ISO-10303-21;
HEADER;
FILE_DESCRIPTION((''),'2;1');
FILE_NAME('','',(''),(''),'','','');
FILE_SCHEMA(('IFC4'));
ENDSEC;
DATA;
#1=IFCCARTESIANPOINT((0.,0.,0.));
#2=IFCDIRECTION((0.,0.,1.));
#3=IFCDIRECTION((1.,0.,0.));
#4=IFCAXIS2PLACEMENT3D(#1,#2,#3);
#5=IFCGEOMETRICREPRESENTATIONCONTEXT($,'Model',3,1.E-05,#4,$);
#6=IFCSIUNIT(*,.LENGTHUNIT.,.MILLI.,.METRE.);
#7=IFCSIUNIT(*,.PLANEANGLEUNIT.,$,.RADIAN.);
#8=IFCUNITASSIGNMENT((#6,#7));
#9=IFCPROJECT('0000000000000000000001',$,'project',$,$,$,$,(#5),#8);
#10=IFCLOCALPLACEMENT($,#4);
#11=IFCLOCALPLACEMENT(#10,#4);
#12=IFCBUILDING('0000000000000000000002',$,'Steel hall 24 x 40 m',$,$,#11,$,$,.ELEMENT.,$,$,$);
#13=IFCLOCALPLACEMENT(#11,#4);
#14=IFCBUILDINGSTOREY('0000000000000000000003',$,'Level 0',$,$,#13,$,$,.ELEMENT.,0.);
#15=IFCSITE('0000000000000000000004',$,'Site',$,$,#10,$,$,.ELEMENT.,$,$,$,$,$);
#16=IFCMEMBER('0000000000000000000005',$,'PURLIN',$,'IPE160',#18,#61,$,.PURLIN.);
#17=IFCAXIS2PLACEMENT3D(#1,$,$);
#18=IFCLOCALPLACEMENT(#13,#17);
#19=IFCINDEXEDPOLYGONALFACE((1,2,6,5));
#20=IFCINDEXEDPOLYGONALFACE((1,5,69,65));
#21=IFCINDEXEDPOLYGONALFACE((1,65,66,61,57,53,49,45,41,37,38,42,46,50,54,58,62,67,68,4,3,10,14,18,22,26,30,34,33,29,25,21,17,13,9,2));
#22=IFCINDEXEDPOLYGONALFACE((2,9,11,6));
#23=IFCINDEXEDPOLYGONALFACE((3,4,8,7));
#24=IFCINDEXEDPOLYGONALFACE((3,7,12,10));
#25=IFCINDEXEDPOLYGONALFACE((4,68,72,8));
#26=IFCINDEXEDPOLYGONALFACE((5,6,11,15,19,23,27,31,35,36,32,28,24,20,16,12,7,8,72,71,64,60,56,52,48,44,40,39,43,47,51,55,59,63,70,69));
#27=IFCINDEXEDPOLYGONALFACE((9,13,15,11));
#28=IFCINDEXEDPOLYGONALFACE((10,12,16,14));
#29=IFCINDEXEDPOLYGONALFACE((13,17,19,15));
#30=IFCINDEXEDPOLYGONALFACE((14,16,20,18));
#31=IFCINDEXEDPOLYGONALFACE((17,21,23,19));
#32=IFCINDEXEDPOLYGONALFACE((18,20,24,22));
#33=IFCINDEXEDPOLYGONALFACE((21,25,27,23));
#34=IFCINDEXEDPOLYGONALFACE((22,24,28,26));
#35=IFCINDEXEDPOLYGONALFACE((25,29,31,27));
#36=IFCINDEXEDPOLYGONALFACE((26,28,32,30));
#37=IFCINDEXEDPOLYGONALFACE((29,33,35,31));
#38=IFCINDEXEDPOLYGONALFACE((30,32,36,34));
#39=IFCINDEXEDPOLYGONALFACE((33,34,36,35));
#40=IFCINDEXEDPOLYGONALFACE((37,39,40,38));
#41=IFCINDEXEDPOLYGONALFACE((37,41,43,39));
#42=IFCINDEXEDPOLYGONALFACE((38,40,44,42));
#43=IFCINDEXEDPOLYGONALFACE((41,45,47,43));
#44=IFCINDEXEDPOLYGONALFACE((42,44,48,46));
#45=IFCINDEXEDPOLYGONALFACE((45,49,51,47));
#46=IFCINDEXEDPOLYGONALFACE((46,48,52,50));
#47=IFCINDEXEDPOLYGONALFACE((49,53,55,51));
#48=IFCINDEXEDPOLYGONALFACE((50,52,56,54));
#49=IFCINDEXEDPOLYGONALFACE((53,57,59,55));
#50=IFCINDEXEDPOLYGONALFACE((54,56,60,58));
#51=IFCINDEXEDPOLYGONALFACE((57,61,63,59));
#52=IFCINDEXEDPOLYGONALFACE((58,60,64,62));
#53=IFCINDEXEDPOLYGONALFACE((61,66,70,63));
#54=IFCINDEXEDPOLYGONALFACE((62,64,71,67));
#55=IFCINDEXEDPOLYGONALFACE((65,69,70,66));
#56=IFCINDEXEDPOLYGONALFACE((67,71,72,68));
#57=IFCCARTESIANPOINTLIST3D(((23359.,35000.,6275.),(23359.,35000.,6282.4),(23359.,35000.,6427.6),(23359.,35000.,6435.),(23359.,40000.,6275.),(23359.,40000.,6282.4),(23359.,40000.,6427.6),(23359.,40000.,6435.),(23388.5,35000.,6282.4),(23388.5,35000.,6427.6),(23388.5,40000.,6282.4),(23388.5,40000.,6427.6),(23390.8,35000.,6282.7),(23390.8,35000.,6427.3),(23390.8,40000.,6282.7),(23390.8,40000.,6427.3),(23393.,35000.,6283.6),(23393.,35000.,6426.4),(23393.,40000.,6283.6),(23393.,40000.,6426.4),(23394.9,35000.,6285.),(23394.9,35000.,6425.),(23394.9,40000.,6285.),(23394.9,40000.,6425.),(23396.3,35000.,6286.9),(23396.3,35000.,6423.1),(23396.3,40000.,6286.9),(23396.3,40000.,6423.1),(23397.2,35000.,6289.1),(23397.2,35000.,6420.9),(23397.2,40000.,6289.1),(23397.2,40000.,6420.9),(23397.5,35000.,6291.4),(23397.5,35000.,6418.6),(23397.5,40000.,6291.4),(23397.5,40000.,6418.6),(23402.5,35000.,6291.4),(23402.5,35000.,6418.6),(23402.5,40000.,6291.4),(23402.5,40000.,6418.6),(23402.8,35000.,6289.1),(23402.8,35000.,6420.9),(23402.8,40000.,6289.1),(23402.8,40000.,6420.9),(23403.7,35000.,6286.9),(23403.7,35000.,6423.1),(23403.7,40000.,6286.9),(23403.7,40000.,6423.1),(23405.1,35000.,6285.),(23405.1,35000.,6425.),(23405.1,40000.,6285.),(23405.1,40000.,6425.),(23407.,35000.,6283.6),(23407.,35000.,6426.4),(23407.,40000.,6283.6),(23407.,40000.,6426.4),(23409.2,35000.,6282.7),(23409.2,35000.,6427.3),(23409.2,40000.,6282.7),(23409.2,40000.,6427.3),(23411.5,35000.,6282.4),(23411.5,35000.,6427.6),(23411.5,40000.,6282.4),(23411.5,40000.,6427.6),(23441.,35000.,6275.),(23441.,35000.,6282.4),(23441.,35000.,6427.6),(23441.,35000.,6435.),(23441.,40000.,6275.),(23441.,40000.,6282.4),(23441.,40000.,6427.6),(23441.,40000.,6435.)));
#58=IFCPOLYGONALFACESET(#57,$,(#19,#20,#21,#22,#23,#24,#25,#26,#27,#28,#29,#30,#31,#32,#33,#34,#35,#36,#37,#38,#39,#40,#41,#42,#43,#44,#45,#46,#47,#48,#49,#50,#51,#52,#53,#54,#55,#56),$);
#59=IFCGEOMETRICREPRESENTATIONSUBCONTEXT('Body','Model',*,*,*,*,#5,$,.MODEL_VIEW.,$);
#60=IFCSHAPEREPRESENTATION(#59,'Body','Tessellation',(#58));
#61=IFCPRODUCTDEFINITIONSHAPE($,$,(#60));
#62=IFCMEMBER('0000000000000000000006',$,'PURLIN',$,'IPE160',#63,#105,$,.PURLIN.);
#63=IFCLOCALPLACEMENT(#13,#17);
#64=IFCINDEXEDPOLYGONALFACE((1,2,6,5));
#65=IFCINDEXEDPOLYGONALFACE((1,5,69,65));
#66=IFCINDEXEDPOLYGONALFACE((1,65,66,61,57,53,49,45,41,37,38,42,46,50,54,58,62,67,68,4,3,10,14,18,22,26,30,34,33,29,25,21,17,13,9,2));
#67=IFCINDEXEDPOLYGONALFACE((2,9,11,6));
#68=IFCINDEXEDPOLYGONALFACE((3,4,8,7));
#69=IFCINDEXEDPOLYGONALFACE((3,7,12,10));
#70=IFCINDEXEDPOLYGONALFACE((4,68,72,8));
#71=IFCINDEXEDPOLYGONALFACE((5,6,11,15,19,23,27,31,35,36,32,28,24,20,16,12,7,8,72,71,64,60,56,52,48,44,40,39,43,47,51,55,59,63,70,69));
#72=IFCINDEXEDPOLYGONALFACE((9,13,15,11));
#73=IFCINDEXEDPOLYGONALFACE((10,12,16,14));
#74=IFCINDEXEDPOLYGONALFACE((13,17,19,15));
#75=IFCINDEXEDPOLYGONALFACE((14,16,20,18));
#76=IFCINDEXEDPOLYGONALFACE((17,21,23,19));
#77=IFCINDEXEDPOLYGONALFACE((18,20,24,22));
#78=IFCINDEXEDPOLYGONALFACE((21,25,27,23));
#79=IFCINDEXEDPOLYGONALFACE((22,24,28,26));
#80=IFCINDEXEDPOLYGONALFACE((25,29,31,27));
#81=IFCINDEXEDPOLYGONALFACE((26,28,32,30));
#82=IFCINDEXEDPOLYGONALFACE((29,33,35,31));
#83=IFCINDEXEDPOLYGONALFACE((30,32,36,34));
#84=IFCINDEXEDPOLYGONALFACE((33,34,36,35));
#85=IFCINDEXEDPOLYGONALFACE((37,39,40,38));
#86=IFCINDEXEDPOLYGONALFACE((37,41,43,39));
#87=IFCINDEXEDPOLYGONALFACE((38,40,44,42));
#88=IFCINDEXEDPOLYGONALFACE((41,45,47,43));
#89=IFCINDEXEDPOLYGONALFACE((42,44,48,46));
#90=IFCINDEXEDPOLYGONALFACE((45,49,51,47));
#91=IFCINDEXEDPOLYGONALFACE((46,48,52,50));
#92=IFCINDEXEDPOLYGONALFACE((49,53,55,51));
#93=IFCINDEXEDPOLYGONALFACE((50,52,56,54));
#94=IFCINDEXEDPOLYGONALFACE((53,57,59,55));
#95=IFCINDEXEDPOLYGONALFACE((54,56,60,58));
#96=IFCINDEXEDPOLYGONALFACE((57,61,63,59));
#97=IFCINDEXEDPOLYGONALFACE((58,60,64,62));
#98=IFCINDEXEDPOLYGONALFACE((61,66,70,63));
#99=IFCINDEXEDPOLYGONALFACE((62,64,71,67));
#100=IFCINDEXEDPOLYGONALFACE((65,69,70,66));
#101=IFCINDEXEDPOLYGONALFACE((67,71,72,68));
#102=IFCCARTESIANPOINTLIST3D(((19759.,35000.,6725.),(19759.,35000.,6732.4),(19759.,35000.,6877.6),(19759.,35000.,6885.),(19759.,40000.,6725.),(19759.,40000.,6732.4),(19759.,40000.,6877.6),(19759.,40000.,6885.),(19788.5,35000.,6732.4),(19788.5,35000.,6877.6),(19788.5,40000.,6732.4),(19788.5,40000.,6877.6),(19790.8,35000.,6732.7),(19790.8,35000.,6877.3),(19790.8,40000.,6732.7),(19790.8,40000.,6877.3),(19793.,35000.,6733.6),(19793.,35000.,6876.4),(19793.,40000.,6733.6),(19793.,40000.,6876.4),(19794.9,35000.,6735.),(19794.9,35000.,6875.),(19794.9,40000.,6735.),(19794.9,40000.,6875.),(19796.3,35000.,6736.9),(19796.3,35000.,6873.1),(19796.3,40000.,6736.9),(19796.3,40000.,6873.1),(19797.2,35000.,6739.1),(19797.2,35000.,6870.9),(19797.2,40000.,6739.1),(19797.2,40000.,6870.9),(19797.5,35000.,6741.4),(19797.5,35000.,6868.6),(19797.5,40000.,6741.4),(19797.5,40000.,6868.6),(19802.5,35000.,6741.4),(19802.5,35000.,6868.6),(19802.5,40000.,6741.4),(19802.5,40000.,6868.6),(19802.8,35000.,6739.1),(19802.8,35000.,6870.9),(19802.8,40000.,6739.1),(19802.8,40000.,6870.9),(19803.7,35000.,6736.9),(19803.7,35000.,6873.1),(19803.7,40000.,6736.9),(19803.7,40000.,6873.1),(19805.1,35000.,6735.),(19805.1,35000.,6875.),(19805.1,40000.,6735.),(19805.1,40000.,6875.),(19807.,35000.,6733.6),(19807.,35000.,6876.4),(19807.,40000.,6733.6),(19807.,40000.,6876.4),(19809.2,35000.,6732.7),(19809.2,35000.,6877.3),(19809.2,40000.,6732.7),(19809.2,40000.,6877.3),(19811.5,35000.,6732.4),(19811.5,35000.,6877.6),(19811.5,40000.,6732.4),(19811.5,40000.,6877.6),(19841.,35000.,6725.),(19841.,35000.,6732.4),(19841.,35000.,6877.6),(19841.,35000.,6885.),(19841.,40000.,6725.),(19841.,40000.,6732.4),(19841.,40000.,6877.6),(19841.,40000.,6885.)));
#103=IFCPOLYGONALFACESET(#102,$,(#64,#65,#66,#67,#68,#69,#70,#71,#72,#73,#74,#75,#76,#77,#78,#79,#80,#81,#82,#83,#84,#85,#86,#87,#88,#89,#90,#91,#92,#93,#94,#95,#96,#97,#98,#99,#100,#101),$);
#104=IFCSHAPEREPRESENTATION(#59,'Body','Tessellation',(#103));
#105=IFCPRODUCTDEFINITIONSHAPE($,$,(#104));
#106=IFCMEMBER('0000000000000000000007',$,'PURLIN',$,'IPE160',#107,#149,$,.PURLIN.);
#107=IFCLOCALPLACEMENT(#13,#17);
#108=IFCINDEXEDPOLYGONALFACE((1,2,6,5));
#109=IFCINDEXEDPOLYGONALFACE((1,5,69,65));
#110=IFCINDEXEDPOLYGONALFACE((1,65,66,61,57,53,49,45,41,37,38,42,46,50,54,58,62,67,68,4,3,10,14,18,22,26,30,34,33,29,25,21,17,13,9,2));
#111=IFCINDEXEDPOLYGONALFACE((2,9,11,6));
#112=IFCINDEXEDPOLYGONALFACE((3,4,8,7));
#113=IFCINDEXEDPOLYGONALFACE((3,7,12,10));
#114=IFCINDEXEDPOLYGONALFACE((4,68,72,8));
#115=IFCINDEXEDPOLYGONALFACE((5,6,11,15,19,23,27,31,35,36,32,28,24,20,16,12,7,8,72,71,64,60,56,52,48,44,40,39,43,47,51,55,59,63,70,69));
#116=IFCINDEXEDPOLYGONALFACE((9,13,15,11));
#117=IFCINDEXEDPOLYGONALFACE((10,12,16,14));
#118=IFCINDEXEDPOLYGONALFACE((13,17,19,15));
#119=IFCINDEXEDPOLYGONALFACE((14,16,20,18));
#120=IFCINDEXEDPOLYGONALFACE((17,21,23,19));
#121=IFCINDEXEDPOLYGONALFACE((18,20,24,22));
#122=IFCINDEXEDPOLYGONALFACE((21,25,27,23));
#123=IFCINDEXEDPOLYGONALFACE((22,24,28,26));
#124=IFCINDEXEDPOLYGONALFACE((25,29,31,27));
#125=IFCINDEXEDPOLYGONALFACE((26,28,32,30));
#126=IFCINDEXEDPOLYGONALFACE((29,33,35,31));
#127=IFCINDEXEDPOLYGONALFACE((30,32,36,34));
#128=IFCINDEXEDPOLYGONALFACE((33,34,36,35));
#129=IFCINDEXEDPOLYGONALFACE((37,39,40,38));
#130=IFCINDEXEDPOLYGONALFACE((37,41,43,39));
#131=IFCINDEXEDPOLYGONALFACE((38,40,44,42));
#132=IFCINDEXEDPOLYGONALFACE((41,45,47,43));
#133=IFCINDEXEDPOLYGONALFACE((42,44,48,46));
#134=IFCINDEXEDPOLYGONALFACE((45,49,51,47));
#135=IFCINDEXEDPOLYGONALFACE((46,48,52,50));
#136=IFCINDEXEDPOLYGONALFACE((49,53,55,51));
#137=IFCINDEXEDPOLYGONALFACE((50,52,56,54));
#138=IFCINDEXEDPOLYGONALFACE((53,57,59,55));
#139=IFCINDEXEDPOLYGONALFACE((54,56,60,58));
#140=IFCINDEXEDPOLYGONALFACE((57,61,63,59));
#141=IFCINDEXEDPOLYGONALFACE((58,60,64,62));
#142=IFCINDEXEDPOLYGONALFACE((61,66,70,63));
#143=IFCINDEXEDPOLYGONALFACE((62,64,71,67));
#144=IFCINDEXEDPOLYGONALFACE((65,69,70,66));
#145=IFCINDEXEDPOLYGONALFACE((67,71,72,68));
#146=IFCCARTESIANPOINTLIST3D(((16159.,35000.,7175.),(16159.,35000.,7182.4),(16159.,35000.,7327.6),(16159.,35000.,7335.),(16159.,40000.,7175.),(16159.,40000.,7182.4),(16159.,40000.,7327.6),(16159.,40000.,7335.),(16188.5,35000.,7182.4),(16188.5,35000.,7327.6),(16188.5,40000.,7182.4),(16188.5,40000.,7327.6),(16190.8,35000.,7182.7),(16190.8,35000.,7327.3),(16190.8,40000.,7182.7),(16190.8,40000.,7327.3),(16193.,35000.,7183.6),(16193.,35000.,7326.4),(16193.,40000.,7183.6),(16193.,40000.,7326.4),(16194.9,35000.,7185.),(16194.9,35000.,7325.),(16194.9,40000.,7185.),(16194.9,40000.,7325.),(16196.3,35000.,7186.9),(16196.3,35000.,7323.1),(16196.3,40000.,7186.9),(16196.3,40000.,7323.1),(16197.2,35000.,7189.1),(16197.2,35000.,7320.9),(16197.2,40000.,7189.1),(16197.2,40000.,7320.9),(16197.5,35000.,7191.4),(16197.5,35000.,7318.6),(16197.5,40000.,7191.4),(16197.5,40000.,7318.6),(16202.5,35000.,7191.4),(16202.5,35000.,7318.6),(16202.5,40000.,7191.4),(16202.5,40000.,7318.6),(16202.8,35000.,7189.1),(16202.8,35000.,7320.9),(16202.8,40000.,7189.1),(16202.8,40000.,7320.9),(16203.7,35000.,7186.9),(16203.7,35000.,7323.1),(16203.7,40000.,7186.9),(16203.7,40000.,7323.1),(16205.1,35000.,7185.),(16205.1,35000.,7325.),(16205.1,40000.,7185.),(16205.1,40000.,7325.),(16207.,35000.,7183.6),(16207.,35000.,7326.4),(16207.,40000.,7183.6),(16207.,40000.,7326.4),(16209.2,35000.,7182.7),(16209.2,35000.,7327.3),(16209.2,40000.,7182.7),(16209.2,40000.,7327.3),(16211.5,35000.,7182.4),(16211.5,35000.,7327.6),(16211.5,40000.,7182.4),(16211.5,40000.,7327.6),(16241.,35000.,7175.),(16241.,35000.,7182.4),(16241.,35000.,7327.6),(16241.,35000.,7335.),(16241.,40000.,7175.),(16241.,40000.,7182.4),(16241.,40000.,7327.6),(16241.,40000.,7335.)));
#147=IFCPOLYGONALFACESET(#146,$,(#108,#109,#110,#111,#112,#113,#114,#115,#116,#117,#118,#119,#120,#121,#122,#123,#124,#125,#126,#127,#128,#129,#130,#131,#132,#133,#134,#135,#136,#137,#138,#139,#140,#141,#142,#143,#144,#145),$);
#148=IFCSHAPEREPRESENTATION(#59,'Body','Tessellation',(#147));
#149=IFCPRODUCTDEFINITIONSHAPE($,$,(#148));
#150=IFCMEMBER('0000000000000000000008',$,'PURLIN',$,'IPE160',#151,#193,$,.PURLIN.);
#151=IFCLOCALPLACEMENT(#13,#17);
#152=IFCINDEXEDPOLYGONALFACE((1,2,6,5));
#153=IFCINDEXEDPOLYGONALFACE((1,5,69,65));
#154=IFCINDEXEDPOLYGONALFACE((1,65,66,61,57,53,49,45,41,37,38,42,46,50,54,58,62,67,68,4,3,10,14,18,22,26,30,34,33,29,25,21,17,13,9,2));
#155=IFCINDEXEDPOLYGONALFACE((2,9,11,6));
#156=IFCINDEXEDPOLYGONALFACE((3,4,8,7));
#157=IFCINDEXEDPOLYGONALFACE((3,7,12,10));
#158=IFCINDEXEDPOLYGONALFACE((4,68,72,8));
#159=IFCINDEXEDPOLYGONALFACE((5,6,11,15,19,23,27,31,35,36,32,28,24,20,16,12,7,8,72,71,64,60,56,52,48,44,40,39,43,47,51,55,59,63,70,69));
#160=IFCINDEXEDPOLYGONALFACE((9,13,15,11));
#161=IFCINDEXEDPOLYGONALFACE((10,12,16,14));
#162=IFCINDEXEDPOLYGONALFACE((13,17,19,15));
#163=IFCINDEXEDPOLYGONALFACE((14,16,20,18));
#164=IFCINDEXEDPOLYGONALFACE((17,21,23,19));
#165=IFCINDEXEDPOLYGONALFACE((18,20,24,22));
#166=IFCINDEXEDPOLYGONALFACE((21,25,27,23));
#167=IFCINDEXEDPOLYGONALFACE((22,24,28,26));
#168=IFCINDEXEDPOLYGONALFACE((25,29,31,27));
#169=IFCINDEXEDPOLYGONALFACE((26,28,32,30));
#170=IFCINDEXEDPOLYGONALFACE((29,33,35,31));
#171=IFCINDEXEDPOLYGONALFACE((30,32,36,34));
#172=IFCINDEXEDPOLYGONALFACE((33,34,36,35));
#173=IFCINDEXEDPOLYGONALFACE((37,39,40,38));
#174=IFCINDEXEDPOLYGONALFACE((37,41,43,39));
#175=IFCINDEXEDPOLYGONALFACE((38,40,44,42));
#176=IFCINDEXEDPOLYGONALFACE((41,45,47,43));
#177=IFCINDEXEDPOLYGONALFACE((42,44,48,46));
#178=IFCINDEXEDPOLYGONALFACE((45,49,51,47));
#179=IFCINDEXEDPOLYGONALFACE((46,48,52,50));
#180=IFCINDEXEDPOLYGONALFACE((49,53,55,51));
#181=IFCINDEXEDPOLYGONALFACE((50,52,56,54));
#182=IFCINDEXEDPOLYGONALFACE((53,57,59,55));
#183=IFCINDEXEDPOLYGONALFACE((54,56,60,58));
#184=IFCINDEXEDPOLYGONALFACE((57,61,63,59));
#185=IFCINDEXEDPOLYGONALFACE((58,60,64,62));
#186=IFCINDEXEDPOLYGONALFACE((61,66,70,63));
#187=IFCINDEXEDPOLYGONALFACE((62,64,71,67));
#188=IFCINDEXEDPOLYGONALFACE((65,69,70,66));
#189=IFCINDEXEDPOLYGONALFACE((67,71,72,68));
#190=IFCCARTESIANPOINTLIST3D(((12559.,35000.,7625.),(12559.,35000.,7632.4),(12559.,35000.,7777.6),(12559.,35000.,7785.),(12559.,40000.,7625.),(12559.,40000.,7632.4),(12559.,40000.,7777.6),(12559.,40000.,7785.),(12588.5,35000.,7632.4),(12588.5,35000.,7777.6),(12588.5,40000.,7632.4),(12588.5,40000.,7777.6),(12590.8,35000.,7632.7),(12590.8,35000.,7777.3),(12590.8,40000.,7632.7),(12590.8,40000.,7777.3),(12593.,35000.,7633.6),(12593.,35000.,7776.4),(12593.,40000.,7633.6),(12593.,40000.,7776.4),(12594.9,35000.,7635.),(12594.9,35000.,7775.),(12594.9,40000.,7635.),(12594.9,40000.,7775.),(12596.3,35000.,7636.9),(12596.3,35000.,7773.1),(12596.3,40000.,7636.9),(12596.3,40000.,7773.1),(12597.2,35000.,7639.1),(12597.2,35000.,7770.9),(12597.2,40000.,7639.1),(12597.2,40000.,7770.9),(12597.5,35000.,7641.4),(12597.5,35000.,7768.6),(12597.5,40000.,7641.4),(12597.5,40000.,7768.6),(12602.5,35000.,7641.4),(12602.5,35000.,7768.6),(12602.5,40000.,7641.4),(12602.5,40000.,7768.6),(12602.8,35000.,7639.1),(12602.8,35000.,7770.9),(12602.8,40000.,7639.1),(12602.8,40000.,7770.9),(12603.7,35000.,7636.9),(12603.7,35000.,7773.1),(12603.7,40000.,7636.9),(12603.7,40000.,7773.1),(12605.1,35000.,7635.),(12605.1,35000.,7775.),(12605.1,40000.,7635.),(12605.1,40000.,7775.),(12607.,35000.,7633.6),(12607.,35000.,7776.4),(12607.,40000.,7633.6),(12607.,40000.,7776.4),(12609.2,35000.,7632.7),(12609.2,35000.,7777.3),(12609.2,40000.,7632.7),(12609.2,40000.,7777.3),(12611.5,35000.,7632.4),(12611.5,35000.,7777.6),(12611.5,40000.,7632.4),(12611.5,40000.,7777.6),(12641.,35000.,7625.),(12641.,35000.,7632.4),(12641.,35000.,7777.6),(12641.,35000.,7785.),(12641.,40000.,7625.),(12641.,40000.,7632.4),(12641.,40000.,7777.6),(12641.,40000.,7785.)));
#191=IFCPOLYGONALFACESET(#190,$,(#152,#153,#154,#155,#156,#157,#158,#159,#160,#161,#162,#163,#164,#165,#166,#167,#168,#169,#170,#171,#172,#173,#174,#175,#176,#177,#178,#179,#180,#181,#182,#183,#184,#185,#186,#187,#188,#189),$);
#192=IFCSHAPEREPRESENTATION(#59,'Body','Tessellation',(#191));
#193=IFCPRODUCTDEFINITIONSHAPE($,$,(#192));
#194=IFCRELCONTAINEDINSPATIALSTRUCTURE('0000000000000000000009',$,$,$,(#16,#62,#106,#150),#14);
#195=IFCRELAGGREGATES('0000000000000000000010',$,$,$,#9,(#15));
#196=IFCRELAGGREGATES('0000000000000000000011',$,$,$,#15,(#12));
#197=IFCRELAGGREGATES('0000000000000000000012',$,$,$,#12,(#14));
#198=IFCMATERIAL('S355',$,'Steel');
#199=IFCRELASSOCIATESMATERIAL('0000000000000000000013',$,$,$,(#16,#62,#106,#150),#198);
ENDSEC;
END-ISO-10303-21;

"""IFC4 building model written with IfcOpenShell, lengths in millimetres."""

from ifc_helpers import new_model, si_unit, frame, origin_with_axes, place, context, subcontext, project, spatial, i_section, extrude, material, element, save


model = new_model("IFC4")

# Units and contexts
model_context = context("Model", 3, precision=1e-05, world=origin_with_axes())
body_context = subcontext(model_context, "Body", "Model", "MODEL_VIEW")
ifc_project = project(units=[si_unit("LENGTHUNIT", "METRE", prefix="MILLI"), si_unit("PLANEANGLEUNIT", "RADIAN")], contexts=[model_context])

# Site, building, storey
site_placement = place(None, origin_with_axes())
site = spatial("IfcSite", under=ifc_project, at=site_placement, Name="Site", CompositionType="ELEMENT")
building_placement = place(site_placement, origin_with_axes())
building = spatial("IfcBuilding", under=site, at=building_placement, Name="Steel hall 24 x 40 m", CompositionType="ELEMENT")
storey_placement = place(building_placement, origin_with_axes())
storey = spatial("IfcBuildingStorey", under=building, at=storey_placement, Name="Level 0", CompositionType="ELEMENT", Elevation=0.0)

# Shared definitions
ifc_material = material(Name="S355", Category="Steel")

# Members
for number, where, z_axis, x_axis, name in (
    (1, (23400.0, 35000.0, 6355.0), (0.0, 1.0, 0.0), (1.0, 0.0, 0.0), "PURLIN"),
    (2, (19800.0, 35000.0, 6805.0), (0.0, 1.0, 0.0), (1.0, 0.0, 0.0), "PURLIN"),
    (3, (16200.0, 35000.0, 7255.0), (0.0, 1.0, 0.0), (1.0, 0.0, 0.0), "PURLIN"),
    (4, (12600.0, 35000.0, 7705.0), (0.0, 1.0, 0.0), (1.0, 0.0, 0.0), "PURLIN"),
):
    element("IfcMember", number, at=place(storey_placement, frame(where, z_axis=z_axis, x_axis=x_axis)), inside=storey, material=ifc_material, Name=name, ObjectType="IPE160", PredefinedType="PURLIN", context=body_context, shape_type="SweptSolid", body=[
        extrude(i_section(OverallWidth=82.0, OverallDepth=160.0, WebThickness=5.0, FlangeThickness=7.4, FilletRadius=9.0), origin_with_axes(), (0.0, 0.0, 1.0), 5000.0),
    ])

save(model, "model.ifc")
